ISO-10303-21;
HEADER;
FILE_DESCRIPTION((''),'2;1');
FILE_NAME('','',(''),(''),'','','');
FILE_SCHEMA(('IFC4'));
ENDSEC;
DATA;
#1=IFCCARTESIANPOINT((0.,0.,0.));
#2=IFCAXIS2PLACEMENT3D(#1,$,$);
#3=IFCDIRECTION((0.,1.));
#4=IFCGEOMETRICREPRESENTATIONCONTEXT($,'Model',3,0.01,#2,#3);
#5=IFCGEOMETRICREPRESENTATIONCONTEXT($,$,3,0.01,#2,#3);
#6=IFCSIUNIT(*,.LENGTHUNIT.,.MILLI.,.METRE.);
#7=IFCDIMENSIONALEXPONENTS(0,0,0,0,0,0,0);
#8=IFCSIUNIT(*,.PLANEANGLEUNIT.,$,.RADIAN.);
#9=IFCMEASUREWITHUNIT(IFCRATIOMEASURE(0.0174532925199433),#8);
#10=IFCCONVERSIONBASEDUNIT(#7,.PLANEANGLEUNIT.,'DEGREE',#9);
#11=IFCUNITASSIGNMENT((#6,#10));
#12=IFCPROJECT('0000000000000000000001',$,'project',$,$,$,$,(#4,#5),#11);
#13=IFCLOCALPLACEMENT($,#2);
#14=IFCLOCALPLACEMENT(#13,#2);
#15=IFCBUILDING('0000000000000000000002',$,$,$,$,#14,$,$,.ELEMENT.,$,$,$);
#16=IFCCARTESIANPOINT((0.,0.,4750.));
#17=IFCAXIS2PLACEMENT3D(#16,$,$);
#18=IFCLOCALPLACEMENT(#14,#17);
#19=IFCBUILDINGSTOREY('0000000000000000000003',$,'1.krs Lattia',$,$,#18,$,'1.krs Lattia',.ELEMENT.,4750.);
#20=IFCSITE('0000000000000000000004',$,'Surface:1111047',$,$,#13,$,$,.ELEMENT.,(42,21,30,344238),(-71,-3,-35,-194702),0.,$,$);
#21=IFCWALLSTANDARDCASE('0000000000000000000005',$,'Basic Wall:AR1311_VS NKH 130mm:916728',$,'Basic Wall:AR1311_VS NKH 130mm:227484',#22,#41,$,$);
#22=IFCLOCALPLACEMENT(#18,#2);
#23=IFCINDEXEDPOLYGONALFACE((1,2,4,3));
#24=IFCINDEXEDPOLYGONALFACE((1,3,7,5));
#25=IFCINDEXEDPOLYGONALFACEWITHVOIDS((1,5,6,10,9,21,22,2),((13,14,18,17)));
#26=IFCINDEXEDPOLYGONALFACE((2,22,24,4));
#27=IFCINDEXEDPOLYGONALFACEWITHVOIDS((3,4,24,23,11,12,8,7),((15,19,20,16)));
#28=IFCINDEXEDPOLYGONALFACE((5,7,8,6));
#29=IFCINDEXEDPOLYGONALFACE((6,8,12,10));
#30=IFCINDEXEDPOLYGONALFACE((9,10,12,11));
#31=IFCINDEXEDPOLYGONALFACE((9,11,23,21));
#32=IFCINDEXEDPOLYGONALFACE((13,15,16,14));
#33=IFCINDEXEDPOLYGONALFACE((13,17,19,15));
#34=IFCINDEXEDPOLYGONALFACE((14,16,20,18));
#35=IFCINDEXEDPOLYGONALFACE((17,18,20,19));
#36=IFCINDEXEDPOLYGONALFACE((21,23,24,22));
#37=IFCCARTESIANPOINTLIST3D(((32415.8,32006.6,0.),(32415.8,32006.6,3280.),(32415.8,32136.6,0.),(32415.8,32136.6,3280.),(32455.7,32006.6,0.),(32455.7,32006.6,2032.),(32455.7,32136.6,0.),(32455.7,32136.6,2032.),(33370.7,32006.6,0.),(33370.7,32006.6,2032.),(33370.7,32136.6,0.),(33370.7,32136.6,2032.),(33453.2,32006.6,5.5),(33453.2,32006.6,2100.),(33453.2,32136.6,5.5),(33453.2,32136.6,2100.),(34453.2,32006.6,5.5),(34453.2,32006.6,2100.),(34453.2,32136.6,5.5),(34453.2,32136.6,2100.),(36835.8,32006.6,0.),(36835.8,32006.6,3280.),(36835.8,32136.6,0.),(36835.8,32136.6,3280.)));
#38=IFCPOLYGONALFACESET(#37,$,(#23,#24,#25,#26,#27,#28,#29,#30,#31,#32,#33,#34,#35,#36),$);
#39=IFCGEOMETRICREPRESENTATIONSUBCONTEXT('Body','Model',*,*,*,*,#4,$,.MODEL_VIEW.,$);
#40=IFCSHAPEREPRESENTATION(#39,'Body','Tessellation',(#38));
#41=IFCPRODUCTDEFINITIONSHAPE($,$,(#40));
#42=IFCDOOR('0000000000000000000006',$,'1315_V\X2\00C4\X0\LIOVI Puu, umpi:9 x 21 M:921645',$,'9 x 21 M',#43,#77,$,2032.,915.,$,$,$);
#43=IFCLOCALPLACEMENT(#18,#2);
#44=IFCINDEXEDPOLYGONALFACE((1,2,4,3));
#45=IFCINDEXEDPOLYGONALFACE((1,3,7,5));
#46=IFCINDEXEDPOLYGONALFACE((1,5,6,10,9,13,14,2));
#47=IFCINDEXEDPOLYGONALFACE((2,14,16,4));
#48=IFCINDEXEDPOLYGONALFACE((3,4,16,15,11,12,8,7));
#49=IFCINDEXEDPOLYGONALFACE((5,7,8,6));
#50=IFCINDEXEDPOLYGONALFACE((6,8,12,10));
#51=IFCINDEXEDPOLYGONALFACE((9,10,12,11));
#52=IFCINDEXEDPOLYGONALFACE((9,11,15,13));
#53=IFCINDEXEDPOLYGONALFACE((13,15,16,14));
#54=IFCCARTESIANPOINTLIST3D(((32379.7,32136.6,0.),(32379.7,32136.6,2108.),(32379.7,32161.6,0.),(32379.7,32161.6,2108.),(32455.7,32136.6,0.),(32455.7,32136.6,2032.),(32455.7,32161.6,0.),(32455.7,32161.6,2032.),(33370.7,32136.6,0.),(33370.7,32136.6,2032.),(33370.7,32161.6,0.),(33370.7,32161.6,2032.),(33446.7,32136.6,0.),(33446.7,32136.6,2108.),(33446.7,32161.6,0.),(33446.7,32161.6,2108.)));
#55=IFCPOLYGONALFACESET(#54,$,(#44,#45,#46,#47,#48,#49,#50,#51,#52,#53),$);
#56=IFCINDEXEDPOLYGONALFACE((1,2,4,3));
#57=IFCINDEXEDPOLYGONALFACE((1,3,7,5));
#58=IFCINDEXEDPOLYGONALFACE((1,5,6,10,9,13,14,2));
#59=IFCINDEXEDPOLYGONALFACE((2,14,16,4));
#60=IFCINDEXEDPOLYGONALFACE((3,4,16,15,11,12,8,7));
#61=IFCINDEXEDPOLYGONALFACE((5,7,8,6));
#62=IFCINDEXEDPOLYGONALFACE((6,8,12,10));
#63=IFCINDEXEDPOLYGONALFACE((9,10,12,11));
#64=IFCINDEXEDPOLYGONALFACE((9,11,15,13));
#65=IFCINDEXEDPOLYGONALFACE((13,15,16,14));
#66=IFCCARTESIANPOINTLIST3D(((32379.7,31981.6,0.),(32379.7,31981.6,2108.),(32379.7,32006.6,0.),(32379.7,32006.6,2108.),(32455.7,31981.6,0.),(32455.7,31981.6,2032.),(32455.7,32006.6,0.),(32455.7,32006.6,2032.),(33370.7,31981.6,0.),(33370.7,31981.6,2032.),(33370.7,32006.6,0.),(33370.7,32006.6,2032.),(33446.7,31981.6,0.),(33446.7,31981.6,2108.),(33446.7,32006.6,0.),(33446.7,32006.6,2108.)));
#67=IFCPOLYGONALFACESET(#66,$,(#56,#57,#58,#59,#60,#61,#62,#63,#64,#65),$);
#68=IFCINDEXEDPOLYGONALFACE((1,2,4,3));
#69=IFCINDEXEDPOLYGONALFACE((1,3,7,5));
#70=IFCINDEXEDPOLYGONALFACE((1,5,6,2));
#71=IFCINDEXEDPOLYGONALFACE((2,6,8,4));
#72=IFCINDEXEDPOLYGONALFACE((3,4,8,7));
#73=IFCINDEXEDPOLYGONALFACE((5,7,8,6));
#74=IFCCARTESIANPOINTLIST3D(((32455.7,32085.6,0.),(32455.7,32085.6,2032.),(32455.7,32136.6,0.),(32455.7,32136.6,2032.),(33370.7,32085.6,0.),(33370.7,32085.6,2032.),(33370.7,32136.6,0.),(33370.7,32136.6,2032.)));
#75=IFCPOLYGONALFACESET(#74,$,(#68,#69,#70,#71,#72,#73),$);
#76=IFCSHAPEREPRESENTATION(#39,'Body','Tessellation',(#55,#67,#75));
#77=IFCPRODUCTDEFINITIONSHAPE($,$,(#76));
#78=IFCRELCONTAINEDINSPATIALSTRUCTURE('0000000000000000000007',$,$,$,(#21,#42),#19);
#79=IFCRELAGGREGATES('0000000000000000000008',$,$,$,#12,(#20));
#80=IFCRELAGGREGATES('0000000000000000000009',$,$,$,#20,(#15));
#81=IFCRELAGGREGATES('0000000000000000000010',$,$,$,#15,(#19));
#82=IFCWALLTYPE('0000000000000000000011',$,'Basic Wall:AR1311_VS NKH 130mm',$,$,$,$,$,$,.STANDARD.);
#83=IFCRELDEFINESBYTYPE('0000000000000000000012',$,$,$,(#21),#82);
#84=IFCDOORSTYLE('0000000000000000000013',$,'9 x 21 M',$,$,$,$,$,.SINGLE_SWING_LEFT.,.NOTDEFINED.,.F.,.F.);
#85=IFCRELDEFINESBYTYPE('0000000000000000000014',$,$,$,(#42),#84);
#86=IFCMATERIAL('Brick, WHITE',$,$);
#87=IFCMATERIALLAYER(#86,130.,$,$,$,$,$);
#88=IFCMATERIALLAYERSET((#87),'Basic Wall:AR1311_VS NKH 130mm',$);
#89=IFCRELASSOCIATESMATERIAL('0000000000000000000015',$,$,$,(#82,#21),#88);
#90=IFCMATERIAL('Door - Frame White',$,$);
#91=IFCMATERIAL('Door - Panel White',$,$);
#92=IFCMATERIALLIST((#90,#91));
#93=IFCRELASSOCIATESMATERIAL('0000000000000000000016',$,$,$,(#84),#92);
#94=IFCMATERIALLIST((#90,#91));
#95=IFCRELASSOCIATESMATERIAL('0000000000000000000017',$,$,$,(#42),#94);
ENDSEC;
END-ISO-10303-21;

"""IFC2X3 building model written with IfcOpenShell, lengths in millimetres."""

from ifc_helpers import new_model, entity, si_unit, converted_unit, direction, frame, frame_2d, origin, place, context, subcontext, project, spatial, polyline, rectangle, outline, extrude, clip, bounded_halfspace, source, transform, mapped, material, material_list, layer, layer_set, layer_usage, type_object, type_shapes, element, fill, save


model = new_model("IFC2X3")

# Units and contexts
model_context = context("Model", 3, precision=0.01, world=origin(), true_north=direction((0.0, 1.0)))
context_of_model = context(None, 3, precision=0.01, world=origin(), true_north=direction((0.0, 1.0)))
body_context = subcontext(model_context, "Body", "Model", "MODEL_VIEW")
ifc_project = project(units=[si_unit("LENGTHUNIT", "METRE", prefix="MILLI"), converted_unit("PLANEANGLEUNIT", "DEGREE", entity("IfcRatioMeasure", 0.0174532925199433), si_unit("PLANEANGLEUNIT", "RADIAN"), dimensions=[0, 0, 0, 0, 0, 0, 0])], contexts=[model_context, context_of_model])

# Site, building, storey
site_placement = place(None, origin())
site = spatial("IfcSite", under=ifc_project, at=site_placement, Name="Surface:1111047", CompositionType="ELEMENT", RefLatitude=(42, 21, 30, 344238), RefLongitude=(-71, -3, -35, -194702), RefElevation=0.0)
building_placement = place(site_placement, origin())
building = spatial("IfcBuilding", under=site, at=building_placement, CompositionType="ELEMENT")
storey_placement = place(building_placement, frame((0.0, 0.0, 4750.0)))
storey = spatial("IfcBuildingStorey", under=building, at=storey_placement, Name="1.krs Lattia", LongName="1.krs Lattia", CompositionType="ELEMENT", Elevation=4750.0)

# Shared definitions
ifc_material_1 = material(Name="Brick, WHITE")
ifc_layer = layer(ifc_material_1, 130.0)
ifc_layer_set = layer_set([ifc_layer], Name="Basic Wall:AR1311_VS NKH 130mm")
wall_type = type_object("IfcWallType", Name="Basic Wall:AR1311_VS NKH 130mm", PredefinedType="STANDARD", material=ifc_layer_set)

# Shared definitions
ifc_material_2 = material(Name="Door - Frame White")
ifc_material_3 = material(Name="Door - Panel White")
ifc_material_list_1 = material_list([ifc_material_2, ifc_material_3])
door_style = type_object("IfcDoorStyle", Name="9 x 21 M", ConstructionType="NOTDEFINED", OperationType="SINGLE_SWING_LEFT", ParameterTakesPrecedence=False, Sizeable=False, material=ifc_material_list_1)
shared_shape_1 = source(origin(), body_context, "Body", "SweptSolid", [
    extrude(outline(polyline([(-533.5, -1073.0), (533.5, -1073.0), (533.5, 1035.0), (457.5, 1035.0), (457.5, -997.0), (-457.5, -997.0), (-457.5, 1035.0), (-533.5, 1035.0), (-533.5, -1073.0)])), frame((457.5, 155.0, 1035.0), z_axis=(0.0, -1.0, 0.0), x_axis=(-1.0, 0.0, 0.0)), (0.0, 0.0, 1.0), 25.0),
    extrude(outline(polyline([(-1073.0, -533.5), (1035.0, -533.5), (1035.0, -457.5), (-997.0, -457.5), (-997.0, 457.5), (1035.0, 457.5), (1035.0, 533.5), (-1073.0, 533.5), (-1073.0, -533.5)])), frame((457.5, 0.0, 1035.0), z_axis=(0.0, -1.0, 0.0), x_axis=(0.0, 0.0, -1.0)), (0.0, 0.0, 1.0), 25.0),
    extrude(rectangle(XDim=915.0, YDim=51.0, at=frame_2d((0.0, 0.0), x_axis=(1.0, 0.0))), frame((457.5, 104.5, 0.0)), (0.0, 0.0, 1.0), 2032.0),
])
type_shapes(door_style, [shared_shape_1])

# Wall, openings, door
ifc_layer_usage_1 = layer_usage(ifc_layer_set, "AXIS2", "NEGATIVE", 65.0)
wall_1_placement = place(storey_placement, frame((36835.8, 32071.6, 0.0), z_axis=(0.0, 0.0, 1.0), x_axis=(-1.0, 0.0, 0.0)))
wall_1 = element("IfcWallStandardCase", 1, at=wall_1_placement, inside=storey, type_object=wall_type, material=ifc_layer_usage_1, Name="Basic Wall:AR1311_VS NKH 130mm:916728", ObjectType="Basic Wall:AR1311_VS NKH 130mm:227484", context=body_context, shape_type="Clipping", body=[
    clip(extrude(rectangle(XDim=4420.0, YDim=130.0, at=frame_2d((2210.0, 0.0), x_axis=(-1.0, 0.0))), origin(), (0.0, 0.0, 1.0), 3280.0), bounded_halfspace(frame((0.0, -65.0, 3280.0), z_axis=(0.0, 0.0, -1.0), x_axis=(0.0, -1.0, 0.0)), True, frame((0.0, -65.0, 3280.0)), polyline([(0.0, 0.0), (4420.0, 0.0), (4420.0, 130.0), (0.0, 130.0), (0.0, 0.0)]))),
])
opening_1_placement = place(wall_1_placement, origin())
element("IfcOpeningElement", 2, at=opening_1_placement, cuts=wall_1, ObjectType="Opening", context=body_context, shape_type="SweptSolid", body=[
    extrude(rectangle(XDim=2094.5, YDim=1000.0, at=frame_2d((0.0, 0.0), x_axis=(1.0, 0.0))), frame((2882.6, -65.0, 1052.8), z_axis=(0.0, 1.0, 0.0), x_axis=(0.0, 0.0, -1.0)), (0.0, 0.0, 1.0), 130.0),
])
opening_2_placement = place(wall_1_placement, frame((4380.1, 65.0, 0.0)))
opening_2 = element("IfcOpeningElement", 3, at=opening_2_placement, cuts=wall_1, ObjectType="Opening", context=body_context, shape_type="SweptSolid", body=[
    extrude(rectangle(XDim=915.0, YDim=2032.0, at=frame_2d((1016.0, 457.5), x_axis=(0.0, -1.0))), frame((0.0, 0.0, 0.0), z_axis=(0.0, -1.0, 0.0), x_axis=(0.0, 0.0, 1.0)), (0.0, 0.0, 1.0), 130.0),
])
ifc_material_list_2 = material_list([ifc_material_2, ifc_material_3])
door_1_placement = place(opening_2_placement, frame((0.0, 0.0, 0.0), z_axis=(0.0, 0.0, 1.0), x_axis=(-1.0, 0.0, 0.0)))
door_1 = element("IfcDoor", 4, at=door_1_placement, inside=storey, type_object=door_style, material=ifc_material_list_2, Name="1315_VÄLIOVI Puu, umpi:9 x 21 M:921645", ObjectType="9 x 21 M", OverallHeight=2032.0, OverallWidth=915.0, context=body_context, shape_type="MappedRepresentation", body=[
    mapped(shared_shape_1, transform((0.0, 0.0, 0.0), scale=1.0)),
])
fill(opening_2, door_1)

save(model, "model.ifc")
